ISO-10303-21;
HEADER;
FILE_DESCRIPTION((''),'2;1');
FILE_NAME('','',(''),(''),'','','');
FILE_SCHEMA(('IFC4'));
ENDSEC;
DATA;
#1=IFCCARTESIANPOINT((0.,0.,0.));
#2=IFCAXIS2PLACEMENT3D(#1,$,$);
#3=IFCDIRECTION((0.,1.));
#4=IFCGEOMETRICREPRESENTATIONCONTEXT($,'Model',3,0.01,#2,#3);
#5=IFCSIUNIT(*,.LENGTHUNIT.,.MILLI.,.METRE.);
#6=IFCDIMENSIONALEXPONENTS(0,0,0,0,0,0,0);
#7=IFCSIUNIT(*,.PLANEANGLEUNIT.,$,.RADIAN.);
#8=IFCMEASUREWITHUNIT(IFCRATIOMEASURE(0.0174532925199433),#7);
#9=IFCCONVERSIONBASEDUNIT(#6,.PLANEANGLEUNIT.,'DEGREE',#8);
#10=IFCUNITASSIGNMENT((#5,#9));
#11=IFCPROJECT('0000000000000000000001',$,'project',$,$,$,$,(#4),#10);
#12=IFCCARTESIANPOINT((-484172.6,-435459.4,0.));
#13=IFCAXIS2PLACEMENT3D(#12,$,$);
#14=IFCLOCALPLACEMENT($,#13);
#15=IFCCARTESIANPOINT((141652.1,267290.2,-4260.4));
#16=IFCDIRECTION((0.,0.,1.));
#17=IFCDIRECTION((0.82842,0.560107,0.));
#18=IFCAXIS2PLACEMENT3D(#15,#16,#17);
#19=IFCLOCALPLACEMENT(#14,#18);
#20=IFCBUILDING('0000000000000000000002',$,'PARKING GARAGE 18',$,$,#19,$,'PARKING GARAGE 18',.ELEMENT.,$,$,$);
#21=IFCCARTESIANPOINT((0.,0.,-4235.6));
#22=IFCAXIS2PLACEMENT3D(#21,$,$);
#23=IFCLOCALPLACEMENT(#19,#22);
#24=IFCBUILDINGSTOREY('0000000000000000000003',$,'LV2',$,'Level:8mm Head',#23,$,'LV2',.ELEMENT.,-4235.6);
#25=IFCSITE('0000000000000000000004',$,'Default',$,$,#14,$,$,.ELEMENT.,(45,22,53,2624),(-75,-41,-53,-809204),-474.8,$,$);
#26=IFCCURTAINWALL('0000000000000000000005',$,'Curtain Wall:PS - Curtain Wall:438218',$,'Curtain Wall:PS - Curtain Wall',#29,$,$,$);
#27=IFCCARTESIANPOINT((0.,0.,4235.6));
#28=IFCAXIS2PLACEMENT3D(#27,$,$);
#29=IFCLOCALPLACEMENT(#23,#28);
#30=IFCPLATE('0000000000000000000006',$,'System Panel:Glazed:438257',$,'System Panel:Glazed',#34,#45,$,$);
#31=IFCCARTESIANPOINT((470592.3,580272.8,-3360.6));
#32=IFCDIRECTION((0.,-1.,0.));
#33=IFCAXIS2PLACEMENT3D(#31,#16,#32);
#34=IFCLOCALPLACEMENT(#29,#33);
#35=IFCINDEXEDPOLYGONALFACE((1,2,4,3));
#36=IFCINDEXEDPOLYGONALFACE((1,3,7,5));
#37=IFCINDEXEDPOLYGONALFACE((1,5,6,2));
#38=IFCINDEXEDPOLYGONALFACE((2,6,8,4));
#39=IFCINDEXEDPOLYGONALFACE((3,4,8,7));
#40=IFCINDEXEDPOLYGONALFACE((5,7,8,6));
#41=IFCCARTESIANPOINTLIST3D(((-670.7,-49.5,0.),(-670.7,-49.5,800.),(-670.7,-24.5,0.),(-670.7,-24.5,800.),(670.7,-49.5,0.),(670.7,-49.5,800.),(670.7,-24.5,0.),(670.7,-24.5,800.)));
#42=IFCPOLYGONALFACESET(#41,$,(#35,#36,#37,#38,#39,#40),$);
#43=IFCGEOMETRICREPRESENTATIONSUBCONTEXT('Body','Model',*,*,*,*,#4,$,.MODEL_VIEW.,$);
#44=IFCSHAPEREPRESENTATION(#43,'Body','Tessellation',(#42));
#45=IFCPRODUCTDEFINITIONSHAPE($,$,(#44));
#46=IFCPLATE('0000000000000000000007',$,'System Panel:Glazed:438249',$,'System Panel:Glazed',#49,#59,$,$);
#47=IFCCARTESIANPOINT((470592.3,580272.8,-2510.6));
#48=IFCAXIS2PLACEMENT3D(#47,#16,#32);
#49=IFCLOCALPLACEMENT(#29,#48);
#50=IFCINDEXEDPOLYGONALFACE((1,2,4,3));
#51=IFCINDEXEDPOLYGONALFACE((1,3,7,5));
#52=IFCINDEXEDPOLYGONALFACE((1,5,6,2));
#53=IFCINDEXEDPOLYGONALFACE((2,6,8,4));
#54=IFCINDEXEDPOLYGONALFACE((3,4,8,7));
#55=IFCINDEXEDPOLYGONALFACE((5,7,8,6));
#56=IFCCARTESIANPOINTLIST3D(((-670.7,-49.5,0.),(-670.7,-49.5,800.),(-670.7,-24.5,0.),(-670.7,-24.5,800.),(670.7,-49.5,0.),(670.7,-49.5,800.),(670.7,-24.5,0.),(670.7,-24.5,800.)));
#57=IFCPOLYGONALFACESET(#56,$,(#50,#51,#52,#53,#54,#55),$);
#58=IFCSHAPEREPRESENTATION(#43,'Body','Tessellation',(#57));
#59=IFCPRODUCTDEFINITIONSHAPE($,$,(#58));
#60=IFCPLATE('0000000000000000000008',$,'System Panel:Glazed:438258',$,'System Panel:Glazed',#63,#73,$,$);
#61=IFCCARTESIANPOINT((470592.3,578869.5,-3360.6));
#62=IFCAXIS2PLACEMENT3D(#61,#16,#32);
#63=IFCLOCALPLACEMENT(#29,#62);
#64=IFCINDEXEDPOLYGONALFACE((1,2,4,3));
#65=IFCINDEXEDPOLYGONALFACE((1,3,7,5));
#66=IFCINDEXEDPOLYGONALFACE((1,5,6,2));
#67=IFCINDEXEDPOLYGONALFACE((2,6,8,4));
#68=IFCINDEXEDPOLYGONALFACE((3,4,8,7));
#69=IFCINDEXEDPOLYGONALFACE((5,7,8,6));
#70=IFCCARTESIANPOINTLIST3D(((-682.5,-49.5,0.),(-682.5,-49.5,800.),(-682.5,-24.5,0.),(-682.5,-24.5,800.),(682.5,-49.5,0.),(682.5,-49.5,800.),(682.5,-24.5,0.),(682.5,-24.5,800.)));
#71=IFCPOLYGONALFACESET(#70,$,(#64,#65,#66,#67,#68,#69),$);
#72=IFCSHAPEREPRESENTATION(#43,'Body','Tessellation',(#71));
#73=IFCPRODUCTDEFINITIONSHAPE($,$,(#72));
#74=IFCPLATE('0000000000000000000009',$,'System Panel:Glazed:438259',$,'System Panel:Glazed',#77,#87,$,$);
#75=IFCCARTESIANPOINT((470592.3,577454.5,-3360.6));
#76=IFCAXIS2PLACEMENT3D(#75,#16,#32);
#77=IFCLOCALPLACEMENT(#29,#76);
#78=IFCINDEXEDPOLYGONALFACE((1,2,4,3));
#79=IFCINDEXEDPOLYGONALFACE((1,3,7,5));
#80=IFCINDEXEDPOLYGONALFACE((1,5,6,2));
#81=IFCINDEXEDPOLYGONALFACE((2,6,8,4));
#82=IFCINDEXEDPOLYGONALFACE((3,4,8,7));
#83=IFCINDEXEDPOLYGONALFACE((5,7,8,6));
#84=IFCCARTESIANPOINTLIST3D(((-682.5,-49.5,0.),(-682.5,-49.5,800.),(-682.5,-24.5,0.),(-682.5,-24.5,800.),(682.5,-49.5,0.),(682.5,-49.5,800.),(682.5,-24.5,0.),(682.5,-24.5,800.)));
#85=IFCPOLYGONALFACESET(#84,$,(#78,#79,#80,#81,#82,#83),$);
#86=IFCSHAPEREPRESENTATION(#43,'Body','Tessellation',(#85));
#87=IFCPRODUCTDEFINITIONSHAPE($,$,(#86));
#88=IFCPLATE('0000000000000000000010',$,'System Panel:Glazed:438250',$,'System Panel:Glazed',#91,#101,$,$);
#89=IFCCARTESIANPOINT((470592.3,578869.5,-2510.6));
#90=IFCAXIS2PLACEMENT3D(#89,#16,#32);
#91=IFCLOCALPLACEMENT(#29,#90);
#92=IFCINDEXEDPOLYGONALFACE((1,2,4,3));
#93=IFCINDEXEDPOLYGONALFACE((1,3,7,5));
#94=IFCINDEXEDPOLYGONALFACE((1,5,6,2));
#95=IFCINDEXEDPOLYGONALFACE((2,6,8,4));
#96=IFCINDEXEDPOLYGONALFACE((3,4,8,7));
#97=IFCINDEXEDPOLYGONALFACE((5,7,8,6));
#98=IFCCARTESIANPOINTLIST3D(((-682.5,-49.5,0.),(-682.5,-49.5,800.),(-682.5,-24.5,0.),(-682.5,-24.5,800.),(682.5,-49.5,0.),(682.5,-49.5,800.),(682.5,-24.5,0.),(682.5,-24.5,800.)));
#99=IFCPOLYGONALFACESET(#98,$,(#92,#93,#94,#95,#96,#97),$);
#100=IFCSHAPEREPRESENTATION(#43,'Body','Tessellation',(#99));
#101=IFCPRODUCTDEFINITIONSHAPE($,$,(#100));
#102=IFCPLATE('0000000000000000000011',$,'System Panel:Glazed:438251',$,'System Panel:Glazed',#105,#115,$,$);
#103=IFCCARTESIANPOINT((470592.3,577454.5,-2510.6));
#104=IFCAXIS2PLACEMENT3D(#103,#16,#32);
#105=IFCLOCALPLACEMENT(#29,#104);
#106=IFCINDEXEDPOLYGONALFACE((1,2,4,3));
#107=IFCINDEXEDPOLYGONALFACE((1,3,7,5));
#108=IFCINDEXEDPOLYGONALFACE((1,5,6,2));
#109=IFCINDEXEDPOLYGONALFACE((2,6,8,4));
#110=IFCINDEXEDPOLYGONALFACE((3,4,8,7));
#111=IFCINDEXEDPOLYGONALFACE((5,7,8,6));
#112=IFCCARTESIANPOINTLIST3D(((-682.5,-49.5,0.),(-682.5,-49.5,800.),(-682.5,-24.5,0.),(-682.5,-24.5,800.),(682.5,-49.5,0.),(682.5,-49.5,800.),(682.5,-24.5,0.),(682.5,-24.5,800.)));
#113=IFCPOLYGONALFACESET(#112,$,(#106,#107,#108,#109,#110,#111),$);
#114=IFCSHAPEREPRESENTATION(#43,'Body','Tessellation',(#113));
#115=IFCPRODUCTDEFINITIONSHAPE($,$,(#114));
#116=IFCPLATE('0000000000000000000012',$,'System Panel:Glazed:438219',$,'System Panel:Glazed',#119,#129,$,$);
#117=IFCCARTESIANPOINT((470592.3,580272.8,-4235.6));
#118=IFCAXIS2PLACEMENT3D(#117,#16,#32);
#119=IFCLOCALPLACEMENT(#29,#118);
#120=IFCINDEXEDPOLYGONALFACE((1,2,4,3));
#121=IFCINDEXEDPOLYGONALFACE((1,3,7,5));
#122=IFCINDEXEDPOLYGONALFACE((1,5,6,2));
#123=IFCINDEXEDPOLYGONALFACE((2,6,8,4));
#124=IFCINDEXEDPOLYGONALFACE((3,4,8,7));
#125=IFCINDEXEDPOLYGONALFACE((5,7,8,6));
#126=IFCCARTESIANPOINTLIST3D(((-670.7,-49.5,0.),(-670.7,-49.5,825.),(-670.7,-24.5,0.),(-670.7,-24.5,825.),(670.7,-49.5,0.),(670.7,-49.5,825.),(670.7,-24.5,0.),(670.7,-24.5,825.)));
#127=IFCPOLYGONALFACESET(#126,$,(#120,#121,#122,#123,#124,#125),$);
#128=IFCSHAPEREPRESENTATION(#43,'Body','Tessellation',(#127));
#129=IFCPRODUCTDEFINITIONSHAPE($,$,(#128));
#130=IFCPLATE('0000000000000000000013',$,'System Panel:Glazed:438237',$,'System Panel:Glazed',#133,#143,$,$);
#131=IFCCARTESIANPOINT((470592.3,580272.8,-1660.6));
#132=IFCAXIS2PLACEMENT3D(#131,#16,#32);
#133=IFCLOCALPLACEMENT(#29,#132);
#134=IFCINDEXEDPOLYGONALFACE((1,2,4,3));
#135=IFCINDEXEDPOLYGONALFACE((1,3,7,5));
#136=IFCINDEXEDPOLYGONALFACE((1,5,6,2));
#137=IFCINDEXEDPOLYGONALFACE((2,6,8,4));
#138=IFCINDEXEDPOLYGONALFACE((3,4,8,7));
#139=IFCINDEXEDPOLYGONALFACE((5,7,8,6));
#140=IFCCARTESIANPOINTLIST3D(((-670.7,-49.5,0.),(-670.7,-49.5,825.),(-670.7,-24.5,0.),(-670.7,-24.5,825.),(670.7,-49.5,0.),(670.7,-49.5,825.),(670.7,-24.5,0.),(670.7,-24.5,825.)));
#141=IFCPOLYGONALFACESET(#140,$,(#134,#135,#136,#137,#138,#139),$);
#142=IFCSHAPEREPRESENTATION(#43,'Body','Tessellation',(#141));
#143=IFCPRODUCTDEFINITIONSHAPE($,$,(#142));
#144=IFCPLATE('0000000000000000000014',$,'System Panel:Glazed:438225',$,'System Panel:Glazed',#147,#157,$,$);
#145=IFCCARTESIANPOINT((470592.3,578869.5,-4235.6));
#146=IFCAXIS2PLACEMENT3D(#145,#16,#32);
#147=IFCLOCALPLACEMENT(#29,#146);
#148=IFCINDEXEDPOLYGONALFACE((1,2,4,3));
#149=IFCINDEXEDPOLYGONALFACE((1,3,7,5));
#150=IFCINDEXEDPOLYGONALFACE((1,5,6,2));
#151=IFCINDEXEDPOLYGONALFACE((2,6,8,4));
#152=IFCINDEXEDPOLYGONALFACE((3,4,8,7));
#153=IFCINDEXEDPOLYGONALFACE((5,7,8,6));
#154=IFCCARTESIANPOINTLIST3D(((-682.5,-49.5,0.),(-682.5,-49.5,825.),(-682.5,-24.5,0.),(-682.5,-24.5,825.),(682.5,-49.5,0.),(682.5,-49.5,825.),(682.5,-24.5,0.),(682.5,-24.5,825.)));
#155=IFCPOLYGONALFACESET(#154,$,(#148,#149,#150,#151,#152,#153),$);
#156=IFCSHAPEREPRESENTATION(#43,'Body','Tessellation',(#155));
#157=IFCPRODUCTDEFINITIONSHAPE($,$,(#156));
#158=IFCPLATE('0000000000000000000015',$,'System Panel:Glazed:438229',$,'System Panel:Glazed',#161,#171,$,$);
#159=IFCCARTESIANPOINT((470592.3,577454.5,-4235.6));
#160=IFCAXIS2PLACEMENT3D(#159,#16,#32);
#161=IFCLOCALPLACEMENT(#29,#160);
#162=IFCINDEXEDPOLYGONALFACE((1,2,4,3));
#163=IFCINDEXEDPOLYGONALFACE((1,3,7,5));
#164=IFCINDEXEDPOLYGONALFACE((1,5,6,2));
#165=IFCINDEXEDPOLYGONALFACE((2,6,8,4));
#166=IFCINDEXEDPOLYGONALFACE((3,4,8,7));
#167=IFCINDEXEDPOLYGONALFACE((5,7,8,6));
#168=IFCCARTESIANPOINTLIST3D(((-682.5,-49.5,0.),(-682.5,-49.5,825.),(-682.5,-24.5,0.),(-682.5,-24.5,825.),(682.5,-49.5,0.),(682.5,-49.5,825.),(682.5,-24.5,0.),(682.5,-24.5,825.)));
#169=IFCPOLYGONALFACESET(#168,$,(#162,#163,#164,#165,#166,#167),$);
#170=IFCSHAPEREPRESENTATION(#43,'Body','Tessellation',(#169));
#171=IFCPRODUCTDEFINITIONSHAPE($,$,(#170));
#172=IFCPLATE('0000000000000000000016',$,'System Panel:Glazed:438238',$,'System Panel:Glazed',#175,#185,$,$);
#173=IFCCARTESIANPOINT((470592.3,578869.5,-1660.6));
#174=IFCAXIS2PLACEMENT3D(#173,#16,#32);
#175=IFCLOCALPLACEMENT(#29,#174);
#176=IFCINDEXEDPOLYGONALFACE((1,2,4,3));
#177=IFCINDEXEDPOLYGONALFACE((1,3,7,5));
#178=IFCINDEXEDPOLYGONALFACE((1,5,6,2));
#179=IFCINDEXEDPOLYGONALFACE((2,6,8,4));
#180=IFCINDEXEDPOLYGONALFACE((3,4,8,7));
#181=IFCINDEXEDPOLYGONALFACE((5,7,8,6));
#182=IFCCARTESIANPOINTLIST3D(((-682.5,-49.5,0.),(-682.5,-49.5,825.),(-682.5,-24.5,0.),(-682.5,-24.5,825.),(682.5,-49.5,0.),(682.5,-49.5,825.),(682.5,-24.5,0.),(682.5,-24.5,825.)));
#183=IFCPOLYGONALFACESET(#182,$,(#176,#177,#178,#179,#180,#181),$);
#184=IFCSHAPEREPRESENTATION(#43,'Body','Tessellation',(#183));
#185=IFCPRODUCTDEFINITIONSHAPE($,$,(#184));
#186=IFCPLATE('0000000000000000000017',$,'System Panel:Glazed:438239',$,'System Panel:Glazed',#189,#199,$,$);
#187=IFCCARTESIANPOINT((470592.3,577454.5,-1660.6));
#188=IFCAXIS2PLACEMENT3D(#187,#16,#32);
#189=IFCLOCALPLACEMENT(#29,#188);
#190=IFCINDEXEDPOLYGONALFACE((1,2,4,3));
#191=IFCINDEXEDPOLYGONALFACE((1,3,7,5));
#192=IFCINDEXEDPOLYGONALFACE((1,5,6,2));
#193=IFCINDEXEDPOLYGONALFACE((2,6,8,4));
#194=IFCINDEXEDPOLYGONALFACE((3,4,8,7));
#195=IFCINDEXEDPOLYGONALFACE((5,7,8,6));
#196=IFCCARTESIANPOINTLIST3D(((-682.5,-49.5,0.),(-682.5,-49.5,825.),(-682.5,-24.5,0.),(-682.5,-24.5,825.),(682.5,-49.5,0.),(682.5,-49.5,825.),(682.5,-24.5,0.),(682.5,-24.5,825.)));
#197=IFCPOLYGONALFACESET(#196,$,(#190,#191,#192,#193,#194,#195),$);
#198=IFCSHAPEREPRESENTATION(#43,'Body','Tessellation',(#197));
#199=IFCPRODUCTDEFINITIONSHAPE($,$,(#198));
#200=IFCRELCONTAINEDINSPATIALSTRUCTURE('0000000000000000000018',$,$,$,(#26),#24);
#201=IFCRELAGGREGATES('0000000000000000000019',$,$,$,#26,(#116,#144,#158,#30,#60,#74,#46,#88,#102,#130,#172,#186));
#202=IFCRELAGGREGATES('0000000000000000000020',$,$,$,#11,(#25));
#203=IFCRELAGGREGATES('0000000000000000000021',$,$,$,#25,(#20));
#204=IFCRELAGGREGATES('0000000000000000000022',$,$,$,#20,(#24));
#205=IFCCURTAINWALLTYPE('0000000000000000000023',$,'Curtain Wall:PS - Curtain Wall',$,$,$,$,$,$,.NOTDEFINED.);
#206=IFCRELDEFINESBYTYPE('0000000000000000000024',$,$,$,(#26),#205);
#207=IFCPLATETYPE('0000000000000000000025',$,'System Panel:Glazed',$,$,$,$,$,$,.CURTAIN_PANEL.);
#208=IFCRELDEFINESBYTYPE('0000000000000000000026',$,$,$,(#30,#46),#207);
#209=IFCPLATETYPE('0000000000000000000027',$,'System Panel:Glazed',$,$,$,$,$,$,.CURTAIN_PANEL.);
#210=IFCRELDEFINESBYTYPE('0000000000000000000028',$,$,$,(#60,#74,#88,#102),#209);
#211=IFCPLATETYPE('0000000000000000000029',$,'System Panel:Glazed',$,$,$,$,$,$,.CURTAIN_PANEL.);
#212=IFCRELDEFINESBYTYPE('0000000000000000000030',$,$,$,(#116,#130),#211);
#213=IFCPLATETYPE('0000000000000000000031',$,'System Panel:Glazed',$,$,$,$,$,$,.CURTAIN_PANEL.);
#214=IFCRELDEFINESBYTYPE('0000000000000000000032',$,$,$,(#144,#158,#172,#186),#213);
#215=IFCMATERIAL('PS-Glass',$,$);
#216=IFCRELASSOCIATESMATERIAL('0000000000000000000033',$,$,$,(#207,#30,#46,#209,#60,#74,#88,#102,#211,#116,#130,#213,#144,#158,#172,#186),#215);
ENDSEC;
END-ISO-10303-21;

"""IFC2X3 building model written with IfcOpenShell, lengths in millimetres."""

from ifc_helpers import new_model, entity, si_unit, converted_unit, direction, frame, frame_2d, origin, place, context, subcontext, project, spatial, rectangle, extrude, source, transform, mapped, material, type_object, type_shapes, element, aggregate, save


model = new_model("IFC2X3")

# Units and contexts
model_context = context("Model", 3, precision=0.01, world=origin(), true_north=direction((0.0, 1.0)))
body_context = subcontext(model_context, "Body", "Model", "MODEL_VIEW")
ifc_project = project(units=[si_unit("LENGTHUNIT", "METRE", prefix="MILLI"), converted_unit("PLANEANGLEUNIT", "DEGREE", entity("IfcRatioMeasure", 0.0174532925199433), si_unit("PLANEANGLEUNIT", "RADIAN"), dimensions=[0, 0, 0, 0, 0, 0, 0])], contexts=[model_context])

# Site, building, storey
site_placement = place(None, frame((-484172.6, -435459.4, 0.0)))
site = spatial("IfcSite", under=ifc_project, at=site_placement, Name="Default", CompositionType="ELEMENT", RefLatitude=(45, 22, 53, 2624), RefLongitude=(-75, -41, -53, -809204), RefElevation=-474.8)
building_placement = place(site_placement, frame((141652.1, 267290.2, -4260.4), z_axis=(0.0, 0.0, 1.0), x_axis=(0.82842, 0.560107, 0.0)))
building = spatial("IfcBuilding", under=site, at=building_placement, Name="PARKING GARAGE 18", LongName="PARKING GARAGE 18", CompositionType="ELEMENT")
storey_placement = place(building_placement, frame((0.0, 0.0, -4235.6)))
storey = spatial("IfcBuildingStorey", under=building, at=storey_placement, Name="LV2", ObjectType="Level:8mm Head", LongName="LV2", CompositionType="ELEMENT", Elevation=-4235.6)

# Curtain wall, plates
curtain_wall_type = type_object("IfcCurtainWallType", Name="Curtain Wall:PS - Curtain Wall", PredefinedType="NOTDEFINED")
curtain_wall_placement = place(storey_placement, frame((0.0, 0.0, 4235.6)))
curtain_wall = element("IfcCurtainWall", 1, at=curtain_wall_placement, inside=storey, type_object=curtain_wall_type, Name="Curtain Wall:PS - Curtain Wall:438218", ObjectType="Curtain Wall:PS - Curtain Wall")
ifc_material_1 = material(Name="PS-Glass")
plate_type_1 = type_object("IfcPlateType", Name="System Panel:Glazed", PredefinedType="CURTAIN_PANEL", material=ifc_material_1)
shared_shape_1 = source(origin(), body_context, "Body", "SweptSolid", [
    extrude(rectangle(XDim=25.0, YDim=1341.5, at=frame_2d((0.0, 0.0), x_axis=(1.0, 0.0))), frame((0.0, -37.0, 0.0), z_axis=(0.0, 0.0, 1.0), x_axis=(0.0, 1.0, 0.0)), (0.0, 0.0, 1.0), 800.0),
])
type_shapes(plate_type_1, [shared_shape_1])
plate_1_placement = place(curtain_wall_placement, frame((470592.3, 580272.8, -3360.6), z_axis=(0.0, 0.0, 1.0), x_axis=(0.0, -1.0, 0.0)))
plate_1 = element("IfcPlate", 2, at=plate_1_placement, type_object=plate_type_1, material=ifc_material_1, Name="System Panel:Glazed:438257", ObjectType="System Panel:Glazed", context=body_context, shape_type="MappedRepresentation", body=[
    mapped(shared_shape_1, transform((0.0, 0.0, 0.0), scale=1.0)),
])
plate_2_placement = place(curtain_wall_placement, frame((470592.3, 580272.8, -2510.6), z_axis=(0.0, 0.0, 1.0), x_axis=(0.0, -1.0, 0.0)))
plate_2 = element("IfcPlate", 3, at=plate_2_placement, type_object=plate_type_1, material=ifc_material_1, Name="System Panel:Glazed:438249", ObjectType="System Panel:Glazed", context=body_context, shape_type="MappedRepresentation", body=[
    mapped(shared_shape_1, transform((0.0, 0.0, 0.0), scale=1.0)),
])
plate_type_2 = type_object("IfcPlateType", Name="System Panel:Glazed", PredefinedType="CURTAIN_PANEL", material=ifc_material_1)
shared_shape_2 = source(origin(), body_context, "Body", "SweptSolid", [
    extrude(rectangle(XDim=25.0, YDim=1365.0, at=frame_2d((0.0, 0.0), x_axis=(1.0, 0.0))), frame((0.0, -37.0, 0.0), z_axis=(0.0, 0.0, 1.0), x_axis=(0.0, 1.0, 0.0)), (0.0, 0.0, 1.0), 800.0),
])
type_shapes(plate_type_2, [shared_shape_2])
plate_3_placement = place(curtain_wall_placement, frame((470592.3, 578869.5, -3360.6), z_axis=(0.0, 0.0, 1.0), x_axis=(0.0, -1.0, 0.0)))
plate_3 = element("IfcPlate", 4, at=plate_3_placement, type_object=plate_type_2, material=ifc_material_1, Name="System Panel:Glazed:438258", ObjectType="System Panel:Glazed", context=body_context, shape_type="MappedRepresentation", body=[
    mapped(shared_shape_2, transform((0.0, 0.0, 0.0), scale=1.0)),
])
plate_4_placement = place(curtain_wall_placement, frame((470592.3, 577454.5, -3360.6), z_axis=(0.0, 0.0, 1.0), x_axis=(0.0, -1.0, 0.0)))
plate_4 = element("IfcPlate", 5, at=plate_4_placement, type_object=plate_type_2, material=ifc_material_1, Name="System Panel:Glazed:438259", ObjectType="System Panel:Glazed", context=body_context, shape_type="MappedRepresentation", body=[
    mapped(shared_shape_2, transform((0.0, 0.0, 0.0), scale=1.0)),
])
plate_5_placement = place(curtain_wall_placement, frame((470592.3, 578869.5, -2510.6), z_axis=(0.0, 0.0, 1.0), x_axis=(0.0, -1.0, 0.0)))
plate_5 = element("IfcPlate", 6, at=plate_5_placement, type_object=plate_type_2, material=ifc_material_1, Name="System Panel:Glazed:438250", ObjectType="System Panel:Glazed", context=body_context, shape_type="MappedRepresentation", body=[
    mapped(shared_shape_2, transform((0.0, 0.0, 0.0), scale=1.0)),
])
plate_6_placement = place(curtain_wall_placement, frame((470592.3, 577454.5, -2510.6), z_axis=(0.0, 0.0, 1.0), x_axis=(0.0, -1.0, 0.0)))
plate_6 = element("IfcPlate", 7, at=plate_6_placement, type_object=plate_type_2, material=ifc_material_1, Name="System Panel:Glazed:438251", ObjectType="System Panel:Glazed", context=body_context, shape_type="MappedRepresentation", body=[
    mapped(shared_shape_2, transform((0.0, 0.0, 0.0), scale=1.0)),
])
plate_type_3 = type_object("IfcPlateType", Name="System Panel:Glazed", PredefinedType="CURTAIN_PANEL", material=ifc_material_1)
shared_shape_3 = source(origin(), body_context, "Body", "SweptSolid", [
    extrude(rectangle(XDim=25.0, YDim=1341.5, at=frame_2d((0.0, 0.0), x_axis=(1.0, 0.0))), frame((0.0, -37.0, 0.0), z_axis=(0.0, 0.0, 1.0), x_axis=(0.0, 1.0, 0.0)), (0.0, 0.0, 1.0), 825.0),
])
type_shapes(plate_type_3, [shared_shape_3])
plate_7_placement = place(curtain_wall_placement, frame((470592.3, 580272.8, -4235.6), z_axis=(0.0, 0.0, 1.0), x_axis=(0.0, -1.0, 0.0)))
plate_7 = element("IfcPlate", 8, at=plate_7_placement, type_object=plate_type_3, material=ifc_material_1, Name="System Panel:Glazed:438219", ObjectType="System Panel:Glazed", context=body_context, shape_type="MappedRepresentation", body=[
    mapped(shared_shape_3, transform((0.0, 0.0, 0.0), scale=1.0)),
])
plate_8_placement = place(curtain_wall_placement, frame((470592.3, 580272.8, -1660.6), z_axis=(0.0, 0.0, 1.0), x_axis=(0.0, -1.0, 0.0)))
plate_8 = element("IfcPlate", 9, at=plate_8_placement, type_object=plate_type_3, material=ifc_material_1, Name="System Panel:Glazed:438237", ObjectType="System Panel:Glazed", context=body_context, shape_type="MappedRepresentation", body=[
    mapped(shared_shape_3, transform((0.0, 0.0, 0.0), scale=1.0)),
])
plate_type_4 = type_object("IfcPlateType", Name="System Panel:Glazed", PredefinedType="CURTAIN_PANEL", material=ifc_material_1)
shared_shape_4 = source(origin(), body_context, "Body", "SweptSolid", [
    extrude(rectangle(XDim=25.0, YDim=1365.0, at=frame_2d((0.0, 0.0), x_axis=(1.0, 0.0))), frame((0.0, -37.0, 0.0), z_axis=(0.0, 0.0, 1.0), x_axis=(0.0, 1.0, 0.0)), (0.0, 0.0, 1.0), 825.0),
])
type_shapes(plate_type_4, [shared_shape_4])
plate_9_placement = place(curtain_wall_placement, frame((470592.3, 578869.5, -4235.6), z_axis=(0.0, 0.0, 1.0), x_axis=(0.0, -1.0, 0.0)))
plate_9 = element("IfcPlate", 10, at=plate_9_placement, type_object=plate_type_4, material=ifc_material_1, Name="System Panel:Glazed:438225", ObjectType="System Panel:Glazed", context=body_context, shape_type="MappedRepresentation", body=[
    mapped(shared_shape_4, transform((0.0, 0.0, 0.0), scale=1.0)),
])
plate_10_placement = place(curtain_wall_placement, frame((470592.3, 577454.5, -4235.6), z_axis=(0.0, 0.0, 1.0), x_axis=(0.0, -1.0, 0.0)))
plate_10 = element("IfcPlate", 11, at=plate_10_placement, type_object=plate_type_4, material=ifc_material_1, Name="System Panel:Glazed:438229", ObjectType="System Panel:Glazed", context=body_context, shape_type="MappedRepresentation", body=[
    mapped(shared_shape_4, transform((0.0, 0.0, 0.0), scale=1.0)),
])
plate_11_placement = place(curtain_wall_placement, frame((470592.3, 578869.5, -1660.6), z_axis=(0.0, 0.0, 1.0), x_axis=(0.0, -1.0, 0.0)))
plate_11 = element("IfcPlate", 12, at=plate_11_placement, type_object=plate_type_4, material=ifc_material_1, Name="System Panel:Glazed:438238", ObjectType="System Panel:Glazed", context=body_context, shape_type="MappedRepresentation", body=[
    mapped(shared_shape_4, transform((0.0, 0.0, 0.0), scale=1.0)),
])
plate_12_placement = place(curtain_wall_placement, frame((470592.3, 577454.5, -1660.6), z_axis=(0.0, 0.0, 1.0), x_axis=(0.0, -1.0, 0.0)))
plate_12 = element("IfcPlate", 13, at=plate_12_placement, type_object=plate_type_4, material=ifc_material_1, Name="System Panel:Glazed:438239", ObjectType="System Panel:Glazed", context=body_context, shape_type="MappedRepresentation", body=[
    mapped(shared_shape_4, transform((0.0, 0.0, 0.0), scale=1.0)),
])
aggregate(curtain_wall, [plate_7, plate_9, plate_10, plate_1, plate_3, plate_4, plate_2, plate_5, plate_6, plate_8, plate_11, plate_12])

save(model, "model.ifc")
